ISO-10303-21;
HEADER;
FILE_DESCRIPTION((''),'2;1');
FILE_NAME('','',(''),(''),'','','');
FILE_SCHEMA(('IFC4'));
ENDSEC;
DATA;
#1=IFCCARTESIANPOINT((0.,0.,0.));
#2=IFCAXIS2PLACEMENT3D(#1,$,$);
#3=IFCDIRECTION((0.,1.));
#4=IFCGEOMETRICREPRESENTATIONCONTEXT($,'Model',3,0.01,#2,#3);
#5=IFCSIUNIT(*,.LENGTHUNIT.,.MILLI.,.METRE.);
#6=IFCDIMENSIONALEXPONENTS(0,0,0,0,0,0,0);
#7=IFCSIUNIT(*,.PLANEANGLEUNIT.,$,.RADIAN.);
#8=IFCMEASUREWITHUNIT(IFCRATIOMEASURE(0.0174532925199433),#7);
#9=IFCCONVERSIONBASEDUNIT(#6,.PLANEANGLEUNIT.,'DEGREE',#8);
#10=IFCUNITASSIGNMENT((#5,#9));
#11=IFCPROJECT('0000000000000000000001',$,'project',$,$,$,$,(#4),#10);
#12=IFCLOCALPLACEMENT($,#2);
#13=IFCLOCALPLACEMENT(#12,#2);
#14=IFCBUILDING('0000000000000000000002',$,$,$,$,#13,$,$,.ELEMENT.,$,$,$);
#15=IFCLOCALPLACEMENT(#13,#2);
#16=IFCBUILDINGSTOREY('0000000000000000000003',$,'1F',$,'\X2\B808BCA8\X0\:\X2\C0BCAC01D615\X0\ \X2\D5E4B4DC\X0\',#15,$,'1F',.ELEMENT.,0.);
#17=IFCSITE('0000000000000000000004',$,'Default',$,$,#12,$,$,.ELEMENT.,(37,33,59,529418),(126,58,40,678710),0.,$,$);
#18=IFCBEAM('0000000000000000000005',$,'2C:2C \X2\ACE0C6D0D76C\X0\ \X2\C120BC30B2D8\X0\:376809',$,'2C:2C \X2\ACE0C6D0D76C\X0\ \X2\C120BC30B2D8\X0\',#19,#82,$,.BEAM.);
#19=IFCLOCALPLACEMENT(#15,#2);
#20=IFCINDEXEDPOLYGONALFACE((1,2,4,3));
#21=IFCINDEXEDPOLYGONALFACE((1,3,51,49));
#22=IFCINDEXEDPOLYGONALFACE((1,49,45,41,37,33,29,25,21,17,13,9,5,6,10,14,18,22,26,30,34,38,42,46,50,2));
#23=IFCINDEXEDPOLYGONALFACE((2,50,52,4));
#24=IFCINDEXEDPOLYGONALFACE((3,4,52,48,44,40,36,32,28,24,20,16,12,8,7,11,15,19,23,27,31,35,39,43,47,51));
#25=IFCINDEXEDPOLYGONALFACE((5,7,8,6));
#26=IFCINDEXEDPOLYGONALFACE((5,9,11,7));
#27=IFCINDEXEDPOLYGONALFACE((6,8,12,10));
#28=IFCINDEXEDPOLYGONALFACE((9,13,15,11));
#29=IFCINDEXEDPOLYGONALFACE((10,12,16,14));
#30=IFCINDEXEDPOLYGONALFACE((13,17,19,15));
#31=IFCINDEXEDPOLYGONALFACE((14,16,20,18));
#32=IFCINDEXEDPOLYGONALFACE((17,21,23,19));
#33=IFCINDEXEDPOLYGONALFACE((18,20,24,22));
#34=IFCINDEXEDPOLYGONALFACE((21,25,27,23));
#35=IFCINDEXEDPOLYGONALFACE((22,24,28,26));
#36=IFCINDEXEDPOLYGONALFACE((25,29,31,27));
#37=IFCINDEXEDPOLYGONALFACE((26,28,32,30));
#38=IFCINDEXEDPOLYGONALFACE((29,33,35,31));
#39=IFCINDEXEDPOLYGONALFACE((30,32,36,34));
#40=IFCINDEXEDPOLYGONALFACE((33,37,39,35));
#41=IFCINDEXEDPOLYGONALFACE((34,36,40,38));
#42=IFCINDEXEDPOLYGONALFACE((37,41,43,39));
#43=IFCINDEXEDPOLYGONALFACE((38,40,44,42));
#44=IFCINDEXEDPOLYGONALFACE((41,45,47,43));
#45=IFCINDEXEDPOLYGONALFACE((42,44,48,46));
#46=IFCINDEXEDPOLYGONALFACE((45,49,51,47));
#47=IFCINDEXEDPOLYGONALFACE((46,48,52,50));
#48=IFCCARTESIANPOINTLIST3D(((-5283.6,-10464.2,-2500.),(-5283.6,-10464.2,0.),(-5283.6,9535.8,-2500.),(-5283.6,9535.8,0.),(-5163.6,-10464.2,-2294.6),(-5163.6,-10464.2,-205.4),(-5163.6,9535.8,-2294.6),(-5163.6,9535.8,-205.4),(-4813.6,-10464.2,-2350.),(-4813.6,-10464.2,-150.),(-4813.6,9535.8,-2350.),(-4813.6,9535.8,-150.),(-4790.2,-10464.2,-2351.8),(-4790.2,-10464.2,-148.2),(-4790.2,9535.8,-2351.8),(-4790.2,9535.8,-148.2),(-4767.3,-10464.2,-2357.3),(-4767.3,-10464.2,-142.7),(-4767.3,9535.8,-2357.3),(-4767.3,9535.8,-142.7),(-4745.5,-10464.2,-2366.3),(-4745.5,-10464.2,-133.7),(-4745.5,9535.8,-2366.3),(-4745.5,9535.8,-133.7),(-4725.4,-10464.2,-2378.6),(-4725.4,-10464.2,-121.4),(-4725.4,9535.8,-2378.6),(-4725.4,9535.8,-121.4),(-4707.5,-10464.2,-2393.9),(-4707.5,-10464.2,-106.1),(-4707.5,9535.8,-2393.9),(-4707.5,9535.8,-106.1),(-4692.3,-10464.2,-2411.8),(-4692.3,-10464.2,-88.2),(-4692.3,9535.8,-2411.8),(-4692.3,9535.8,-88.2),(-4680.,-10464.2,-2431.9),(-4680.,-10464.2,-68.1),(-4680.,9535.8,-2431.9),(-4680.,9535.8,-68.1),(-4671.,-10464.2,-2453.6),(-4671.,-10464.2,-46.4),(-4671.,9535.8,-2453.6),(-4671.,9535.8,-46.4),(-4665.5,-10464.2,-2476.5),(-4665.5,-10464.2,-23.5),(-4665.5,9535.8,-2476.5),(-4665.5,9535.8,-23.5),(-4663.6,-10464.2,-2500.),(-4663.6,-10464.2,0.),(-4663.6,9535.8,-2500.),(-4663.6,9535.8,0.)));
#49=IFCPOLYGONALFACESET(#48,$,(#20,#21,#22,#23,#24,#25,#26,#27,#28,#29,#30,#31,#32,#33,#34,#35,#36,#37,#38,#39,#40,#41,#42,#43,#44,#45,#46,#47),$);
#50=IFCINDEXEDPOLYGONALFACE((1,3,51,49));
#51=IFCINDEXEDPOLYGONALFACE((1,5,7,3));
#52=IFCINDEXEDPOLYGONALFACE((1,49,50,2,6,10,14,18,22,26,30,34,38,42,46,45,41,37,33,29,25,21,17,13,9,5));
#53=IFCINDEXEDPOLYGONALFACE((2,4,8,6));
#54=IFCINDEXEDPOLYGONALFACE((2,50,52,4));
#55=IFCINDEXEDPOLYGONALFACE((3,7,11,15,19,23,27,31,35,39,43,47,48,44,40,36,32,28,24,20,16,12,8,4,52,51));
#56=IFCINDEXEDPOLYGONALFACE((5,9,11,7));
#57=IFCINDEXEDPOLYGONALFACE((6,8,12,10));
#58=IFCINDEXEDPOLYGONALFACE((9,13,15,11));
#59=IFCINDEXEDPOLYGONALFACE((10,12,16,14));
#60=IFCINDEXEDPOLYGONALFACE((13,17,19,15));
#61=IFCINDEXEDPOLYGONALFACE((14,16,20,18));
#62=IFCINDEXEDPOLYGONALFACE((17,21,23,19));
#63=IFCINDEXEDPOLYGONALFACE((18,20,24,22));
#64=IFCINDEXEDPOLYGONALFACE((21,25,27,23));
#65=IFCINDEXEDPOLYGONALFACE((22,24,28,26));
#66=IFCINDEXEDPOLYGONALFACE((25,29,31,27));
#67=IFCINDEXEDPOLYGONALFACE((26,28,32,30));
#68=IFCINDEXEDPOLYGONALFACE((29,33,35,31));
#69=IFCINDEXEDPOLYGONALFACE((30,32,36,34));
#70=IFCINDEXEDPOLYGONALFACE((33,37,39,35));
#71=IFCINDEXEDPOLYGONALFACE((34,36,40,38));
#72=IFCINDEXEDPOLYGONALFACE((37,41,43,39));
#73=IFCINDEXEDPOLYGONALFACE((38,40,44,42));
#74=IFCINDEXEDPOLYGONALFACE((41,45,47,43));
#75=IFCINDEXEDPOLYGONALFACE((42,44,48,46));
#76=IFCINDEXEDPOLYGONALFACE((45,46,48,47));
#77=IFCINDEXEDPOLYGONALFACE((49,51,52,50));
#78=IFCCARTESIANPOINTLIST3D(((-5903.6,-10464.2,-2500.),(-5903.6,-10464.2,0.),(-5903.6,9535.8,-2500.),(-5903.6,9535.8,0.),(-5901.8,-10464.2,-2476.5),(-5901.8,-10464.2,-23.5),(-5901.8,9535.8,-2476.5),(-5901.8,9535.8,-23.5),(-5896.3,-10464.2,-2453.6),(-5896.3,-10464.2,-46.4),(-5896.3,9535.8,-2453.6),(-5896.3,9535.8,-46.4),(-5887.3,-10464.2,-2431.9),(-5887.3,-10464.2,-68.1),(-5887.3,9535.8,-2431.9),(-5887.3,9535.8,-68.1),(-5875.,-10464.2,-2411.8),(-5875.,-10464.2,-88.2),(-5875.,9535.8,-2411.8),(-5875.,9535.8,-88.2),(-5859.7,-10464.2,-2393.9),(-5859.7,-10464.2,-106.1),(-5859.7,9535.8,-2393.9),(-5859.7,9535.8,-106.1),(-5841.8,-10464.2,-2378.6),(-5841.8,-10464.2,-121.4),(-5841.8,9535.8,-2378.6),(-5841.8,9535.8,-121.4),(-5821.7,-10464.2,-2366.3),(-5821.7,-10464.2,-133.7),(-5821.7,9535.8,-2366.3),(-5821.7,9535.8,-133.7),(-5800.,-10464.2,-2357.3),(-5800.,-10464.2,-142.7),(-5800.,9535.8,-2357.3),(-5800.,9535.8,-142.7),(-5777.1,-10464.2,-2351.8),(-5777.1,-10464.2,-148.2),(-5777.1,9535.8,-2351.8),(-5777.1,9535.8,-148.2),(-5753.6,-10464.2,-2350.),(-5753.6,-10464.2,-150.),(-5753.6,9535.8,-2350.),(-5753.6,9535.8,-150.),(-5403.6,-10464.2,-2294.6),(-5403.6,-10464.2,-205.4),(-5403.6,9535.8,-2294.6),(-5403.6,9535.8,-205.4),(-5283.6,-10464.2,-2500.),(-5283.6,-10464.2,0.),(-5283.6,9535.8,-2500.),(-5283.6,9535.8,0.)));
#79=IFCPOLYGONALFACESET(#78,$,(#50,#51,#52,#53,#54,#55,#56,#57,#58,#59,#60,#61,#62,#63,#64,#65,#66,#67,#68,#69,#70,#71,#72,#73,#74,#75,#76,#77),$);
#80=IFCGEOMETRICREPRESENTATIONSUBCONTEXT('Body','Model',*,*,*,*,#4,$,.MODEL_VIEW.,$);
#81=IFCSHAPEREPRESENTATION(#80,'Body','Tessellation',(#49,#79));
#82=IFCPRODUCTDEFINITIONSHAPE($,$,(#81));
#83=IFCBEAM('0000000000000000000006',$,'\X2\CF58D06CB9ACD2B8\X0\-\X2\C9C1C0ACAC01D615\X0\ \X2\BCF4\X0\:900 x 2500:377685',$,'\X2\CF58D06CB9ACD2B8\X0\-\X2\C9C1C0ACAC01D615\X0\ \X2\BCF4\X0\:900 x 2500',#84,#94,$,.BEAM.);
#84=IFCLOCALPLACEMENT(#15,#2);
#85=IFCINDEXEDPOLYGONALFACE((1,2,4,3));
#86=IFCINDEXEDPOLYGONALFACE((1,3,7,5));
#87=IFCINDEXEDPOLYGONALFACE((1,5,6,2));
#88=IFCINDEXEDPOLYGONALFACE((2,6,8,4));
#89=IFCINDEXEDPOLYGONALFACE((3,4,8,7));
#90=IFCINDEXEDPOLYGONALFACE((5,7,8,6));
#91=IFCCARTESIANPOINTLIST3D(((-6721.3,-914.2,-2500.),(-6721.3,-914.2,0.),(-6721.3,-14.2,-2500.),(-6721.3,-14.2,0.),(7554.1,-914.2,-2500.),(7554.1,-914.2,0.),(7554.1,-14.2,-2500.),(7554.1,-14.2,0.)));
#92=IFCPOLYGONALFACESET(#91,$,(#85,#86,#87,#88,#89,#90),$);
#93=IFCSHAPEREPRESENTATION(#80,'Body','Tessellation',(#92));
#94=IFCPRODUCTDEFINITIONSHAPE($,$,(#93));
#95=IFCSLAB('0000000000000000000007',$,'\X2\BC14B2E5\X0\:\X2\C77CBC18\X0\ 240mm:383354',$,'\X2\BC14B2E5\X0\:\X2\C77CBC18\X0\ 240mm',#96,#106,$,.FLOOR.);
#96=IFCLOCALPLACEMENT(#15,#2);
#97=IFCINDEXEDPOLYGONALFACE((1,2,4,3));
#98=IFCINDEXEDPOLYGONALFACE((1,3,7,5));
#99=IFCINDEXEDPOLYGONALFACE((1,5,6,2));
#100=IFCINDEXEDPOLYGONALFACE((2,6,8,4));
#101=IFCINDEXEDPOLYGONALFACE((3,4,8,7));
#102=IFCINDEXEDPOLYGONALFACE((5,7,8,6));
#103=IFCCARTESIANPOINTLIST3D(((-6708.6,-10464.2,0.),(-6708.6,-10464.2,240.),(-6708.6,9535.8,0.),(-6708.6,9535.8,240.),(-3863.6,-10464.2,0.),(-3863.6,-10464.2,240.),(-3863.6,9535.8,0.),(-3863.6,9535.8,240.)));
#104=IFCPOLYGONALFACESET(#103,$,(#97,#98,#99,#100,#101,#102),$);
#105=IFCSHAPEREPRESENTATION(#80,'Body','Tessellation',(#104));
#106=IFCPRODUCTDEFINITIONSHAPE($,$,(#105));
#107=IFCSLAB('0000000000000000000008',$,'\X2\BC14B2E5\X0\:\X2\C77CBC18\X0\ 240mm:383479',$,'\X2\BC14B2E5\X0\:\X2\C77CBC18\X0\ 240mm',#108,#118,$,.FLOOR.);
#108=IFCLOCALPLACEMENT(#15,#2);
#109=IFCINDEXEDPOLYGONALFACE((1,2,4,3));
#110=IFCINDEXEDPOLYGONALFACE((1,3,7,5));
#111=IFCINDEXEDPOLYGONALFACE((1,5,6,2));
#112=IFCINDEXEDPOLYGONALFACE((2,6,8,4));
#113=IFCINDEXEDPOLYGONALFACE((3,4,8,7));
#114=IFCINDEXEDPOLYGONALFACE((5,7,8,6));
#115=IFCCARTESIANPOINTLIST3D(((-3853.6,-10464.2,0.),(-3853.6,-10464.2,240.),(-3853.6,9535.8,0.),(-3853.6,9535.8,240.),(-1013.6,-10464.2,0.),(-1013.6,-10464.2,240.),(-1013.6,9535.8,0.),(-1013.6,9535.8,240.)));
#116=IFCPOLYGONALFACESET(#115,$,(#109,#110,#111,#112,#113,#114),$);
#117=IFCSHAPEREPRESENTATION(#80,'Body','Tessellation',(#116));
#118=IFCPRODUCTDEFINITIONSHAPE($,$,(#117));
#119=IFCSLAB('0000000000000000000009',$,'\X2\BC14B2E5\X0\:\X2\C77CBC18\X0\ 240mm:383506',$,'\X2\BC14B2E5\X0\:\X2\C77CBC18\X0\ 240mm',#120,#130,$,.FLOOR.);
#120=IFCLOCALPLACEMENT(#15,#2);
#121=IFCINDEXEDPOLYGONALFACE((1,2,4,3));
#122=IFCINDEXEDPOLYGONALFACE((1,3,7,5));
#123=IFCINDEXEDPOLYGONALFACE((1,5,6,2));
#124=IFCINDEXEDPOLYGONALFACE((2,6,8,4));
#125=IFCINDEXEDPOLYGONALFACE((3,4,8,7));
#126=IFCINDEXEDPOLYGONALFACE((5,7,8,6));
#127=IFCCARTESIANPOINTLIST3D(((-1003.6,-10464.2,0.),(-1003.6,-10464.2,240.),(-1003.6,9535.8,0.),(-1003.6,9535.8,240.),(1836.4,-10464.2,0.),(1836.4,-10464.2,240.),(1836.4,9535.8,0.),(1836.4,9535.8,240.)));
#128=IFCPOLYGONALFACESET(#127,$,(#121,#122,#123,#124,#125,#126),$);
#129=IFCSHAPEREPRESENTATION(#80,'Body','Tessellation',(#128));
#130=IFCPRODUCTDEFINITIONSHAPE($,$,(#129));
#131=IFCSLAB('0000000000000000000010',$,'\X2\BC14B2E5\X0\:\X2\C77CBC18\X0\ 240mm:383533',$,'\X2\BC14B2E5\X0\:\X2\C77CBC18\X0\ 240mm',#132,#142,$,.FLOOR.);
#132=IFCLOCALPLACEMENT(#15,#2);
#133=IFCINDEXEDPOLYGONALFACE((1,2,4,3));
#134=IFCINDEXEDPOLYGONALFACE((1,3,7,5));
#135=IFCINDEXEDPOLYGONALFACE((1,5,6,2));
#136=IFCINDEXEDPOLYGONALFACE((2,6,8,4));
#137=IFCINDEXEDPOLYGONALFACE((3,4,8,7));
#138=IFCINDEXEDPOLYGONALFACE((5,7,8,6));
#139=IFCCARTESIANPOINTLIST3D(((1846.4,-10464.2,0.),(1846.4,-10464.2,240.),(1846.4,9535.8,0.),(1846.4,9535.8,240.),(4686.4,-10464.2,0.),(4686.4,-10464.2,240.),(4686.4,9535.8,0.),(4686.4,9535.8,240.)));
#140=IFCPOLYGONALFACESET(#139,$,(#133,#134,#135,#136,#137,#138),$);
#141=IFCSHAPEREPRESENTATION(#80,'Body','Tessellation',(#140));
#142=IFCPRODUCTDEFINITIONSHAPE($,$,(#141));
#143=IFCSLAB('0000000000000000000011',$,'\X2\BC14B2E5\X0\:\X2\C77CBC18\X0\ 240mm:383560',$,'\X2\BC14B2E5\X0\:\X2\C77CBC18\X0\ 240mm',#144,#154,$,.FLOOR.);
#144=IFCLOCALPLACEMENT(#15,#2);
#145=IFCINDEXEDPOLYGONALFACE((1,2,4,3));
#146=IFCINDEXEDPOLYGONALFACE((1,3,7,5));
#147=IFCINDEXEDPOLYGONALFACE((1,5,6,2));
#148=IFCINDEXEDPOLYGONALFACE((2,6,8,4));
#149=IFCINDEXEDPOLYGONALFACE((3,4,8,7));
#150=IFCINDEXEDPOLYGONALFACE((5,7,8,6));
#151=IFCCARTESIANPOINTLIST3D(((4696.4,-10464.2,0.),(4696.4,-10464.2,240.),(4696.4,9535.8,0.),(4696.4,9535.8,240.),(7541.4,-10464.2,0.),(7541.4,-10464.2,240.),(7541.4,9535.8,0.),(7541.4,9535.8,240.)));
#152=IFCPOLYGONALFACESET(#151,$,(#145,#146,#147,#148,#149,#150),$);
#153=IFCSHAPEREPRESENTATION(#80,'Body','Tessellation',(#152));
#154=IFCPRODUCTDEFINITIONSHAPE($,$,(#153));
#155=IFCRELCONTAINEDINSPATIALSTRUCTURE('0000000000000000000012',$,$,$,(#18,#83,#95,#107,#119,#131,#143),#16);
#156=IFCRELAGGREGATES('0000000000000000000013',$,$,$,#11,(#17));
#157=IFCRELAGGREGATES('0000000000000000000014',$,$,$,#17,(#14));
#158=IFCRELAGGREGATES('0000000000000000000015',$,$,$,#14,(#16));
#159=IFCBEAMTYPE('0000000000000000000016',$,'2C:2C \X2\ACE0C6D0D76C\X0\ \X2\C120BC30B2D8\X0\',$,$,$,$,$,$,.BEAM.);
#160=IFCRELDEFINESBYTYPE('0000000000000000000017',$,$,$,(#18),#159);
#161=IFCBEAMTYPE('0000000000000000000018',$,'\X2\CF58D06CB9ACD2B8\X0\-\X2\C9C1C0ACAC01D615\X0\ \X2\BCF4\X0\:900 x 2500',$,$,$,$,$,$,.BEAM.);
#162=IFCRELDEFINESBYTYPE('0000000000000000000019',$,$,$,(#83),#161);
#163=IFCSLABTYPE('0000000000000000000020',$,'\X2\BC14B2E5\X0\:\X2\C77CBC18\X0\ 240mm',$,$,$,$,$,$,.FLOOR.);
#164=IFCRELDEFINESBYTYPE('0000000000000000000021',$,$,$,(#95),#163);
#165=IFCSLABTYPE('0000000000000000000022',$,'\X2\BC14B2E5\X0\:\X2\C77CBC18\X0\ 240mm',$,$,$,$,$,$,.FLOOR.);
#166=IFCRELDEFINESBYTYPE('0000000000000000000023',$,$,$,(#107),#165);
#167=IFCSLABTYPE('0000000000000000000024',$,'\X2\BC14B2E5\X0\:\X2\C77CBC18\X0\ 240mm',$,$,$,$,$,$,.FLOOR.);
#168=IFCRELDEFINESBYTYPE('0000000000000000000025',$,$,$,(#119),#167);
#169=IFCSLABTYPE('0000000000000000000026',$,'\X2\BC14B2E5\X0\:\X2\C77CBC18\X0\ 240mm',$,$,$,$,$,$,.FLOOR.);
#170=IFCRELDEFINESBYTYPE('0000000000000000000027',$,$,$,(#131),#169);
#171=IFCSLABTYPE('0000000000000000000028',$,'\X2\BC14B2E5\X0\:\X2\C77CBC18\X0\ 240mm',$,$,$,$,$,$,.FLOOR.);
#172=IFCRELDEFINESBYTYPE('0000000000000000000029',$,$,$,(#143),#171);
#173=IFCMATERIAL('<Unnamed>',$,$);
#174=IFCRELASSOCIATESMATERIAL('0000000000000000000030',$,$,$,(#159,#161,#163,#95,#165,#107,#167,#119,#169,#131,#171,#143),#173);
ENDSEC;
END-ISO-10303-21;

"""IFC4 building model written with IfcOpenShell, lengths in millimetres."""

from ifc_helpers import new_model, entity, si_unit, converted_unit, direction, frame, origin, place, context, subcontext, project, spatial, indexed_curve, outline, extrude, source, transform, mapped, material, type_object, type_shapes, element, save


model = new_model("IFC4")

# Units and contexts
model_context = context("Model", 3, precision=0.01, world=origin(), true_north=direction((0.0, 1.0)))
body_context = subcontext(model_context, "Body", "Model", "MODEL_VIEW")
ifc_project = project(units=[si_unit("LENGTHUNIT", "METRE", prefix="MILLI"), converted_unit("PLANEANGLEUNIT", "DEGREE", entity("IfcRatioMeasure", 0.0174532925199433), si_unit("PLANEANGLEUNIT", "RADIAN"), dimensions=[0, 0, 0, 0, 0, 0, 0])], contexts=[model_context])

# Site, building, storey
site_placement = place(None, origin())
site = spatial("IfcSite", under=ifc_project, at=site_placement, Name="Default", CompositionType="ELEMENT", RefLatitude=(37, 33, 59, 529418), RefLongitude=(126, 58, 40, 678710), RefElevation=0.0)
building_placement = place(site_placement, origin())
building = spatial("IfcBuilding", under=site, at=building_placement, CompositionType="ELEMENT")
storey_placement = place(building_placement, origin())
storey = spatial("IfcBuildingStorey", under=building, at=storey_placement, Name="1F", ObjectType="레벨:삼각형 헤드", LongName="1F", CompositionType="ELEMENT", Elevation=0.0)

# Beams
ifc_material = material(Name="<Unnamed>")
beam_type_1 = type_object("IfcBeamType", Name="2C:2C 고원희 선배님", PredefinedType="BEAM", material=ifc_material)
shared_shape_1 = source(origin(), body_context, "Body", "SweptSolid", [
    extrude(outline(indexed_curve([(-1250.0, -302.5), (1250.0, -302.5), (1250.0, 317.5), (1226.5, 315.7), (1203.6, 310.2), (1181.9, 301.2), (1161.8, 288.9), (1143.9, 273.6), (1128.6, 255.7), (1116.3, 235.6), (1107.3, 213.9), (1101.8, 191.0), (1100.0, 167.5), (1044.6, -182.5), (-1044.6, -182.5), (-1100.0, 167.5), (-1101.8, 191.0), (-1107.3, 213.9), (-1116.3, 235.6), (-1128.6, 255.7), (-1143.9, 273.6), (-1161.8, 288.9), (-1181.9, 301.2), (-1203.6, 310.2), (-1226.5, 315.7), (-1250.0, 317.5), (-1250.0, -302.5)], self_intersect=False)), frame((-10000.0, 302.5, 0.0), z_axis=(1.0, 0.0, 0.0), x_axis=(0.0, 0.0, -1.0)), (0.0, 0.0, 1.0), 20000.0),
    extrude(outline(indexed_curve([(-317.5, -1250.0), (302.5, -1250.0), (302.5, 1250.0), (-317.5, 1250.0), (-315.7, 1226.5), (-310.2, 1203.6), (-301.2, 1181.9), (-288.9, 1161.8), (-273.6, 1143.9), (-255.7, 1128.6), (-235.6, 1116.3), (-213.9, 1107.3), (-191.0, 1101.8), (-167.5, 1100.0), (182.5, 1044.6), (182.5, -1044.6), (-167.5, -1100.0), (-191.0, -1101.8), (-213.9, -1107.3), (-235.6, -1116.3), (-255.7, -1128.6), (-273.6, -1143.9), (-288.9, -1161.8), (-301.2, -1181.9), (-310.2, -1203.6), (-315.7, -1226.5), (-317.5, -1250.0)], self_intersect=False)), frame((-10000.0, -302.5, 0.0), z_axis=(1.0, 0.0, 0.0), x_axis=(0.0, 1.0, 0.0)), (0.0, 0.0, 1.0), 20000.0),
])
type_shapes(beam_type_1, [shared_shape_1])
for number, where, z_axis, x_axis, name in (
    (1, (-5283.6, -464.2, -1250.0), (0.0, 0.0, 1.0), (0.0, -1.0, 0.0), "2C:2C 고원희 선배님:376809"),
):
    element("IfcBeam", number, at=place(storey_placement, frame(where, z_axis=z_axis, x_axis=x_axis)), inside=storey, type_object=beam_type_1, Name=name, ObjectType="2C:2C 고원희 선배님", PredefinedType="BEAM", context=body_context, shape_type="MappedRepresentation", body=[
        mapped(shared_shape_1, transform((0.0, 0.0, 0.0), scale=1.0)),
    ])
beam_type_2 = type_object("IfcBeamType", Name="콘크리트-직사각형 보:900 x 2500", PredefinedType="BEAM", material=ifc_material)
shared_shape_2 = source(origin(), body_context, "Body", "SweptSolid", [
    extrude(outline(indexed_curve([(-1250.0, -450.0), (1250.0, -450.0), (1250.0, 450.0), (-1250.0, 450.0), (-1250.0, -450.0)], self_intersect=False)), frame((-7137.7, 0.0, 0.0), z_axis=(1.0, 0.0, 0.0), x_axis=(0.0, 0.0, -1.0)), (0.0, 0.0, 1.0), 14275.4),
])
type_shapes(beam_type_2, [shared_shape_2])
beam_placement = place(storey_placement, frame((416.4, -464.2, -1250.0)))
element("IfcBeam", 2, at=beam_placement, inside=storey, type_object=beam_type_2, Name="콘크리트-직사각형 보:900 x 2500:377685", ObjectType="콘크리트-직사각형 보:900 x 2500", PredefinedType="BEAM", context=body_context, shape_type="MappedRepresentation", body=[
    mapped(shared_shape_2, transform((0.0, 0.0, 0.0), scale=1.0)),
])

# Slabs
slab_type_1 = type_object("IfcSlabType", Name="바닥:일반 240mm", PredefinedType="FLOOR", material=ifc_material)
slab_1_placement = place(storey_placement, origin())
element("IfcSlab", 3, at=slab_1_placement, inside=storey, type_object=slab_type_1, material=ifc_material, Name="바닥:일반 240mm:383354", ObjectType="바닥:일반 240mm", PredefinedType="FLOOR", context=body_context, shape_type="SweptSolid", body=[
    extrude(outline(indexed_curve([(-10000.0, -1422.5), (10000.0, -1422.5), (10000.0, 1422.5), (-10000.0, 1422.5), (-10000.0, -1422.5)], self_intersect=False)), frame((-5286.1, -464.2, 240.0), z_axis=(0.0, 0.0, -1.0), x_axis=(0.0, 1.0, 0.0)), (0.0, 0.0, 1.0), 240.0),
])
slab_type_2 = type_object("IfcSlabType", Name="바닥:일반 240mm", PredefinedType="FLOOR", material=ifc_material)
slab_2_placement = place(storey_placement, origin())
element("IfcSlab", 4, at=slab_2_placement, inside=storey, type_object=slab_type_2, material=ifc_material, Name="바닥:일반 240mm:383479", ObjectType="바닥:일반 240mm", PredefinedType="FLOOR", context=body_context, shape_type="SweptSolid", body=[
    extrude(outline(indexed_curve([(-10000.0, -1420.0), (10000.0, -1420.0), (10000.0, 1420.0), (-10000.0, 1420.0), (-10000.0, -1420.0)], self_intersect=False)), frame((-2433.6, -464.2, 240.0), z_axis=(0.0, 0.0, -1.0), x_axis=(0.0, 1.0, 0.0)), (0.0, 0.0, 1.0), 240.0),
])
slab_type_3 = type_object("IfcSlabType", Name="바닥:일반 240mm", PredefinedType="FLOOR", material=ifc_material)
slab_3_placement = place(storey_placement, origin())
element("IfcSlab", 5, at=slab_3_placement, inside=storey, type_object=slab_type_3, material=ifc_material, Name="바닥:일반 240mm:383506", ObjectType="바닥:일반 240mm", PredefinedType="FLOOR", context=body_context, shape_type="SweptSolid", body=[
    extrude(outline(indexed_curve([(-10000.0, -1420.0), (10000.0, -1420.0), (10000.0, 1420.0), (-10000.0, 1420.0), (-10000.0, -1420.0)], self_intersect=False)), frame((416.4, -464.2, 240.0), z_axis=(0.0, 0.0, -1.0), x_axis=(0.0, 1.0, 0.0)), (0.0, 0.0, 1.0), 240.0),
])
slab_type_4 = type_object("IfcSlabType", Name="바닥:일반 240mm", PredefinedType="FLOOR", material=ifc_material)
slab_4_placement = place(storey_placement, origin())
element("IfcSlab", 6, at=slab_4_placement, inside=storey, type_object=slab_type_4, material=ifc_material, Name="바닥:일반 240mm:383533", ObjectType="바닥:일반 240mm", PredefinedType="FLOOR", context=body_context, shape_type="SweptSolid", body=[
    extrude(outline(indexed_curve([(-10000.0, -1420.0), (10000.0, -1420.0), (10000.0, 1420.0), (-10000.0, 1420.0), (-10000.0, -1420.0)], self_intersect=False)), frame((3266.4, -464.2, 240.0), z_axis=(0.0, 0.0, -1.0), x_axis=(0.0, 1.0, 0.0)), (0.0, 0.0, 1.0), 240.0),
])
slab_type_5 = type_object("IfcSlabType", Name="바닥:일반 240mm", PredefinedType="FLOOR", material=ifc_material)
slab_5_placement = place(storey_placement, origin())
element("IfcSlab", 7, at=slab_5_placement, inside=storey, type_object=slab_type_5, material=ifc_material, Name="바닥:일반 240mm:383560", ObjectType="바닥:일반 240mm", PredefinedType="FLOOR", context=body_context, shape_type="SweptSolid", body=[
    extrude(outline(indexed_curve([(-10000.0, -1422.5), (10000.0, -1422.5), (10000.0, 1422.5), (-10000.0, 1422.5), (-10000.0, -1422.5)], self_intersect=False)), frame((6118.9, -464.2, 240.0), z_axis=(0.0, 0.0, -1.0), x_axis=(0.0, 1.0, 0.0)), (0.0, 0.0, 1.0), 240.0),
])

save(model, "model.ifc")
